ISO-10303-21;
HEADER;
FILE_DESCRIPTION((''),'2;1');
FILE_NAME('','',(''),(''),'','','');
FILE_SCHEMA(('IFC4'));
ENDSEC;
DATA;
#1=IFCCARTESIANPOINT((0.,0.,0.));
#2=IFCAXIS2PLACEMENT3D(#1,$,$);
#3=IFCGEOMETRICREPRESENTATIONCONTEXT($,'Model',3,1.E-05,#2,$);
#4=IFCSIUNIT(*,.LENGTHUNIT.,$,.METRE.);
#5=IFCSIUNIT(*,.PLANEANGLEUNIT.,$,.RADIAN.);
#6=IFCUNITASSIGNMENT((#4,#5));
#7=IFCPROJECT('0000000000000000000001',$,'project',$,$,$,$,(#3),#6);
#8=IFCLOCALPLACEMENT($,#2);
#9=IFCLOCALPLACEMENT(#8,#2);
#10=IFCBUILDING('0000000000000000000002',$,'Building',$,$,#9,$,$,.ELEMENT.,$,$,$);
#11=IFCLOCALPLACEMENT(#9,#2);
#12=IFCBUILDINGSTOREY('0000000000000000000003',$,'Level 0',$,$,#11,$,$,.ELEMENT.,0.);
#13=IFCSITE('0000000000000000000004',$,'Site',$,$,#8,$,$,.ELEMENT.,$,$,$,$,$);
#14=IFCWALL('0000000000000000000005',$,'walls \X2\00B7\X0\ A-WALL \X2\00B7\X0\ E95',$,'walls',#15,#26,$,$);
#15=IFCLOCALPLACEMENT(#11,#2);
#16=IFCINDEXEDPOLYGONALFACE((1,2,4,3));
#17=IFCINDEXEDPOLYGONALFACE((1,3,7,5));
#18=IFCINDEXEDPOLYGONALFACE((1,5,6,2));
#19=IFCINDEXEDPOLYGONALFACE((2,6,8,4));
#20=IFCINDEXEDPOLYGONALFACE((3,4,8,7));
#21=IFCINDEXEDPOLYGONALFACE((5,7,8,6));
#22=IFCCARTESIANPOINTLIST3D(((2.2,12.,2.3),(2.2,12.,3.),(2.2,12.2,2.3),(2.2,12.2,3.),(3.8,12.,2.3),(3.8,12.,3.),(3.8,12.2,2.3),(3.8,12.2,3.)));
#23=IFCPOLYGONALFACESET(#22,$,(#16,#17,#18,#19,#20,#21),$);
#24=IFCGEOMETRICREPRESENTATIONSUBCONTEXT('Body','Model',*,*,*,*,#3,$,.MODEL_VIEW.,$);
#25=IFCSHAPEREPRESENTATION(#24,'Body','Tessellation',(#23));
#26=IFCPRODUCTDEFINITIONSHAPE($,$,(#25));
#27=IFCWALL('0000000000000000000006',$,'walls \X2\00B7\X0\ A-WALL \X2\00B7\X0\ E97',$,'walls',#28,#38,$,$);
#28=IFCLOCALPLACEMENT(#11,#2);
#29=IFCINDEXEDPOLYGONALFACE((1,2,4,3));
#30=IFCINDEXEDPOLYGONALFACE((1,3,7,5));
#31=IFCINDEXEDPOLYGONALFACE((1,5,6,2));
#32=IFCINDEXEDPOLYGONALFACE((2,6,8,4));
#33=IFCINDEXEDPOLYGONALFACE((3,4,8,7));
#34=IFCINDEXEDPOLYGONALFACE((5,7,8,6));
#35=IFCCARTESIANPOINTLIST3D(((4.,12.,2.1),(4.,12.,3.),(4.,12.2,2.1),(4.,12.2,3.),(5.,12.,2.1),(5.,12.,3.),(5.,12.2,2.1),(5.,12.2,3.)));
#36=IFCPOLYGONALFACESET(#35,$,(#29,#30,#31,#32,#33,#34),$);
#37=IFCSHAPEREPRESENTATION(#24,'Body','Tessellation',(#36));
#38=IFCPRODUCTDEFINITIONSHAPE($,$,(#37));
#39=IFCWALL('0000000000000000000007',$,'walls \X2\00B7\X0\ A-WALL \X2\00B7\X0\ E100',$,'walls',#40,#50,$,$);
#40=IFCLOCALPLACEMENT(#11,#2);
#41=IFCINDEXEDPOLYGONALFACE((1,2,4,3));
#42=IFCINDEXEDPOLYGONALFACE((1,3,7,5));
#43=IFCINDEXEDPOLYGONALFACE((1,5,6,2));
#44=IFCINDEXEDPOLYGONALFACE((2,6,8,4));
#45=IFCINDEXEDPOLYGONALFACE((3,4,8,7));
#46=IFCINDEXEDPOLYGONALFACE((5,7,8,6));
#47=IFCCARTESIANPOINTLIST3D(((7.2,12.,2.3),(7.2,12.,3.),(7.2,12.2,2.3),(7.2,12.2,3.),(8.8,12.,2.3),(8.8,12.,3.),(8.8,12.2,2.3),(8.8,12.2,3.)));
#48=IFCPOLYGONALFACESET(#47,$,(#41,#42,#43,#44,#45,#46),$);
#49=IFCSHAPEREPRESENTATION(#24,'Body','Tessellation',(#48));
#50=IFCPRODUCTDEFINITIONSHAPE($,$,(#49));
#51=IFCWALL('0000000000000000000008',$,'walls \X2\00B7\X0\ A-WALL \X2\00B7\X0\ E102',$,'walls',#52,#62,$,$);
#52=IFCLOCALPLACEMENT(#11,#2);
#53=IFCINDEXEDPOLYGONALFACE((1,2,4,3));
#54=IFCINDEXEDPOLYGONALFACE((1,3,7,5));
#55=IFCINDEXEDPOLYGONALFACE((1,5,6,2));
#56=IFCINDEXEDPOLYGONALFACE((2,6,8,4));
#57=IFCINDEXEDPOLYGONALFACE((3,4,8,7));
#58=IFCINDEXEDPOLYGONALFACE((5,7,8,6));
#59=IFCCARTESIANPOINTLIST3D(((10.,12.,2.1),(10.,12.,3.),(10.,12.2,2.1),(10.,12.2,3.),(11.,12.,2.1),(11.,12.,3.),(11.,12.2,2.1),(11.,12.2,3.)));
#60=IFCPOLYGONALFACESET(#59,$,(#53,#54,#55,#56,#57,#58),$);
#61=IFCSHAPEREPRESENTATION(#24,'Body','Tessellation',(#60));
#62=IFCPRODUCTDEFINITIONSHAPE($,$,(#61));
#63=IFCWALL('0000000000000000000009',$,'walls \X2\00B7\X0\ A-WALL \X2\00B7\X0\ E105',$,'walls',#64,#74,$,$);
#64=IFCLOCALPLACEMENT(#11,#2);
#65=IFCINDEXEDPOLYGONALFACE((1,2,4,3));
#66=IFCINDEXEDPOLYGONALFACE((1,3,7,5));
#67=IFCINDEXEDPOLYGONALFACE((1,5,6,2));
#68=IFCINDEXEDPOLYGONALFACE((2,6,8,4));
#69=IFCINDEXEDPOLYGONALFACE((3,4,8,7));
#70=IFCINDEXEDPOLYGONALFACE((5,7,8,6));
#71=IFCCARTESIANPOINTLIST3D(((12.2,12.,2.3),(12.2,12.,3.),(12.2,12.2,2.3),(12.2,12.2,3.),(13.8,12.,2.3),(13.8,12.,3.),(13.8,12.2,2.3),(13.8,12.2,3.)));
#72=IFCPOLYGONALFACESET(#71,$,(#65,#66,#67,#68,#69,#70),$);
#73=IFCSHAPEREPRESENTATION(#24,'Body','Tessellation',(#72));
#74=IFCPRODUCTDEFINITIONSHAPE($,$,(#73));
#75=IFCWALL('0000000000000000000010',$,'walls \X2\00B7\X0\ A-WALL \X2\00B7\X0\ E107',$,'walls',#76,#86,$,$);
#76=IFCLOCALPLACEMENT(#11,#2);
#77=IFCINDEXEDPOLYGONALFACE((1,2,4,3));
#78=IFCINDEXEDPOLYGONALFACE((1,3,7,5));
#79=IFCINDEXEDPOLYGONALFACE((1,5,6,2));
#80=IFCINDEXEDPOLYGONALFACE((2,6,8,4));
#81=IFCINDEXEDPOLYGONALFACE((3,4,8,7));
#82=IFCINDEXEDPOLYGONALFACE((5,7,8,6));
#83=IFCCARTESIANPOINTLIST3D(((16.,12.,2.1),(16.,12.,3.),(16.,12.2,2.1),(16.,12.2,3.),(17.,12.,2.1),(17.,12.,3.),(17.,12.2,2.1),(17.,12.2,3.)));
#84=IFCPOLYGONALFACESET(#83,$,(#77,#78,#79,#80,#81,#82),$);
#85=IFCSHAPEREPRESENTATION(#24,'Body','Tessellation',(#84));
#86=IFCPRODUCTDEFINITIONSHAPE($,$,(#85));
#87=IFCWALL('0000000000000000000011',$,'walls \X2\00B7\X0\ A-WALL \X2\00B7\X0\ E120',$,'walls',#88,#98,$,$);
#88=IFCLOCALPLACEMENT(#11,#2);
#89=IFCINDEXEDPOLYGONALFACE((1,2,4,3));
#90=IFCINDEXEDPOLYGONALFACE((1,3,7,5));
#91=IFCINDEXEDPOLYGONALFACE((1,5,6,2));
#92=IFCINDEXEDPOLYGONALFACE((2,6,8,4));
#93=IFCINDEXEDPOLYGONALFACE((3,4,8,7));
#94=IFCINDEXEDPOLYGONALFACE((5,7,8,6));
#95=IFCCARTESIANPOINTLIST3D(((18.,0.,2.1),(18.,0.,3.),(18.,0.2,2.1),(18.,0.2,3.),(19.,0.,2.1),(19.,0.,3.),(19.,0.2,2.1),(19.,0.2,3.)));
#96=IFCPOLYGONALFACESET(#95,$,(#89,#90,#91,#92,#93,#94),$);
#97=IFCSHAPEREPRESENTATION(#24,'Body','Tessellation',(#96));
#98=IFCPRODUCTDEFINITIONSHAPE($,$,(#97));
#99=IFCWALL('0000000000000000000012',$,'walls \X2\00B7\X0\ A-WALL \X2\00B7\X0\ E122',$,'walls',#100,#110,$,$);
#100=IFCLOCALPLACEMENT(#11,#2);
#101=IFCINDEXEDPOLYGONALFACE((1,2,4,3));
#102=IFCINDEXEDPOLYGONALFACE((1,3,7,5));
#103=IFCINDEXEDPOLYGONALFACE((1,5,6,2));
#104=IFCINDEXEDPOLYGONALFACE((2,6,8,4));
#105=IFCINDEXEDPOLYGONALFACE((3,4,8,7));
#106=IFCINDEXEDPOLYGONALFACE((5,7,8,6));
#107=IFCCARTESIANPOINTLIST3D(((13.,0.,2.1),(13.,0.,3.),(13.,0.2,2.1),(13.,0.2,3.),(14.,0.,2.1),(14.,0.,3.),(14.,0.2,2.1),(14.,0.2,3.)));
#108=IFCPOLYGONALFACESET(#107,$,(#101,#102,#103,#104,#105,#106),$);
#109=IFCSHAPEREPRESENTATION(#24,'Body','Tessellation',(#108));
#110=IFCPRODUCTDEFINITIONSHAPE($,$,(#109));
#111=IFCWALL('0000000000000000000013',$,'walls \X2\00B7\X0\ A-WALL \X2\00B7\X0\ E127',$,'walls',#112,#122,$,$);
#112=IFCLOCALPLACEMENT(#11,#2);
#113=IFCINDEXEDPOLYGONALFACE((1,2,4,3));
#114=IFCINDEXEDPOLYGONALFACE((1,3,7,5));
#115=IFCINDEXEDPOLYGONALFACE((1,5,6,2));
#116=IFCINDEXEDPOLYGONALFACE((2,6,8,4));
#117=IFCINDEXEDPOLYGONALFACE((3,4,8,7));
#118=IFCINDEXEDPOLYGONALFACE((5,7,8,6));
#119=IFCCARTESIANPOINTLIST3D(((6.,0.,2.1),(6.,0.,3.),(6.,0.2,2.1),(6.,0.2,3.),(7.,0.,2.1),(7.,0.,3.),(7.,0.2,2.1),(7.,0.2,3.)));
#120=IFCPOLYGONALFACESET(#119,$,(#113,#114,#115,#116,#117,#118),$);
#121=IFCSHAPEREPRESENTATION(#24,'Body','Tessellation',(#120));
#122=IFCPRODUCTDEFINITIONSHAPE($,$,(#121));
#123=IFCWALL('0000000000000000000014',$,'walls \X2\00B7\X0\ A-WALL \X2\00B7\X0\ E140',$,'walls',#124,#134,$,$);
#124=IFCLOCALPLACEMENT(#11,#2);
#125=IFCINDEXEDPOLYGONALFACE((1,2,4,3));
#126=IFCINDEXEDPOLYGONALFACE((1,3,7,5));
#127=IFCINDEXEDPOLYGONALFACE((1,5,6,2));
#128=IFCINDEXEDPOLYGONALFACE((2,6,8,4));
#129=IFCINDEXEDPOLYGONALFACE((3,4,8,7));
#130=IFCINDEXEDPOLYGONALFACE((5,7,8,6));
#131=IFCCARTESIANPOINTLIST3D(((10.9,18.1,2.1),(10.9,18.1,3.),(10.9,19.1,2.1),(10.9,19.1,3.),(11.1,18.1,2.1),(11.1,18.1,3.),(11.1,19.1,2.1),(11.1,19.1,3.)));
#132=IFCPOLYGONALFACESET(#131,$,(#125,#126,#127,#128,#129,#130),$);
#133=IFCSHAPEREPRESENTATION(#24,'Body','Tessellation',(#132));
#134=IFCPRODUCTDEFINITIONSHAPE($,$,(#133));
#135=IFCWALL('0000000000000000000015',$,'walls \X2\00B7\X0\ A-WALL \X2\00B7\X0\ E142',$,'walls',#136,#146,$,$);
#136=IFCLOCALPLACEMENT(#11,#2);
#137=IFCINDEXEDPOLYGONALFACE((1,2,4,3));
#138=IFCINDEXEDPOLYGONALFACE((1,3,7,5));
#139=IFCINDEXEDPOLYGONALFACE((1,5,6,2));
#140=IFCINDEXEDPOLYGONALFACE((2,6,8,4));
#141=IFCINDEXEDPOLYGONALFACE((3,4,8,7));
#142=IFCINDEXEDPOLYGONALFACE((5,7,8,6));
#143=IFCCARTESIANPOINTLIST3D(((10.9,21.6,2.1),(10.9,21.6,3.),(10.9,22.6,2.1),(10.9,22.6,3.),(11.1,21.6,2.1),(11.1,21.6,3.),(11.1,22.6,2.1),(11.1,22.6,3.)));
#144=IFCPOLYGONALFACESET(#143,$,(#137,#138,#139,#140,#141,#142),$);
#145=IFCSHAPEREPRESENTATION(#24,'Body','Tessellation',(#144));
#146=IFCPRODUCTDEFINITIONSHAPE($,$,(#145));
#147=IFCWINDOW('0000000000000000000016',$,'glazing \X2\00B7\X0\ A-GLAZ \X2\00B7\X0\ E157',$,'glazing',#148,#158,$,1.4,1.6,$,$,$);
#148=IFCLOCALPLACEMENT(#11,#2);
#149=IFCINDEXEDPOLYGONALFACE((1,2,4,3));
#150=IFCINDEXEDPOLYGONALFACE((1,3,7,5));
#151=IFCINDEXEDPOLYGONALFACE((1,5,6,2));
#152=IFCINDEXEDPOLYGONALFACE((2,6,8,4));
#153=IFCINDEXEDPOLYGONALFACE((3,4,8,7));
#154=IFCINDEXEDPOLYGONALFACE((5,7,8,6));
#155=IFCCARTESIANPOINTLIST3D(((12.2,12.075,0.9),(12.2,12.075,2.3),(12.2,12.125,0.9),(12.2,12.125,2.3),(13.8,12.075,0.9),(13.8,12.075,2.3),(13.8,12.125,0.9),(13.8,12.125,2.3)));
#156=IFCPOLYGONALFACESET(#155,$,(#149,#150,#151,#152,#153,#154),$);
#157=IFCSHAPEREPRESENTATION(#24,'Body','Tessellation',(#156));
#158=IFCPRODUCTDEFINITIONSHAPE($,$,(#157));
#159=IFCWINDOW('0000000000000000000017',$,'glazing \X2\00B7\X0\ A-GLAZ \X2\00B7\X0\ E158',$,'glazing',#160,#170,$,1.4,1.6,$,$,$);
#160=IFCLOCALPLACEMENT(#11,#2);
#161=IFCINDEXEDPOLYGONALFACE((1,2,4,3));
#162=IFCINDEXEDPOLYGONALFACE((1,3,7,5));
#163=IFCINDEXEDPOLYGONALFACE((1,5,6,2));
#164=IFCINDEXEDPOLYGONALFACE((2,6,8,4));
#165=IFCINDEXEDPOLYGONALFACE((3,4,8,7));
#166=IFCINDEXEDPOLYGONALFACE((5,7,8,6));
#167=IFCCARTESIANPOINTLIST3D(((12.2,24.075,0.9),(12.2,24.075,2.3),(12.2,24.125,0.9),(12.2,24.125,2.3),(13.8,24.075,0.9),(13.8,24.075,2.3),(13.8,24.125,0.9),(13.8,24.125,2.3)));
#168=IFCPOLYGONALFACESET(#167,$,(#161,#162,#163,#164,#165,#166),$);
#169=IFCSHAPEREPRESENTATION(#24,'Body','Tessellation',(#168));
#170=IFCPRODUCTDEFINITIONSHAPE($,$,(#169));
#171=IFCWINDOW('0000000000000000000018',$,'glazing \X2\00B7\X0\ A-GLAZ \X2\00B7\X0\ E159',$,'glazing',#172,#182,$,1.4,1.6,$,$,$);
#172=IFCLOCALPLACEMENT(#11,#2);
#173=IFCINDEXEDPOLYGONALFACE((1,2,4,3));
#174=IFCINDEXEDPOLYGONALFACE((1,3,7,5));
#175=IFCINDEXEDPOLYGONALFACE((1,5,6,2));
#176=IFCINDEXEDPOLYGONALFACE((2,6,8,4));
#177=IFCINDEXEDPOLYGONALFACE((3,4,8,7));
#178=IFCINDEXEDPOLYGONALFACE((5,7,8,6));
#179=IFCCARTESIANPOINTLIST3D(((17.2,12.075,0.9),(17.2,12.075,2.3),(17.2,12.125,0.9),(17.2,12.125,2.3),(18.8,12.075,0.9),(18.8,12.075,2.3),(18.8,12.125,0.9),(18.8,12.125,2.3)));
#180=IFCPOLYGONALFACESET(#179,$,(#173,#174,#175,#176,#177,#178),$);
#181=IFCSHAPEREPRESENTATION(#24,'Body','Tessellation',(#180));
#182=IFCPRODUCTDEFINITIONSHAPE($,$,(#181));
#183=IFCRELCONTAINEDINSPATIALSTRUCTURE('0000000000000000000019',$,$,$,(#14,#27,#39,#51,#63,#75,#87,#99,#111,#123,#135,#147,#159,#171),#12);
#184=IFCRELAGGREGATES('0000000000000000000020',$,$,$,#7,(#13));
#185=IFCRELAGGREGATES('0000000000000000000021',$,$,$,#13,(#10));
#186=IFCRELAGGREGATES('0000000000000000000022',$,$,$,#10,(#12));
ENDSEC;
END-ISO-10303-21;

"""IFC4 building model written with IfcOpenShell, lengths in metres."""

from ifc_helpers import new_model, si_unit, frame, origin, place, context, subcontext, project, spatial, polyline, outline, extrude, element, save


model = new_model("IFC4")

# Units and contexts
model_context = context("Model", 3, precision=1e-05, world=origin())
body_context = subcontext(model_context, "Body", "Model", "MODEL_VIEW")
ifc_project = project(units=[si_unit("LENGTHUNIT", "METRE"), si_unit("PLANEANGLEUNIT", "RADIAN")], contexts=[model_context])

# Site, building, storey
site_placement = place(None, origin())
site = spatial("IfcSite", under=ifc_project, at=site_placement, Name="Site", CompositionType="ELEMENT")
building_placement = place(site_placement, origin())
building = spatial("IfcBuilding", under=site, at=building_placement, Name="Building", CompositionType="ELEMENT")
storey_placement = place(building_placement, origin())
storey = spatial("IfcBuildingStorey", under=building, at=storey_placement, Name="Level 0", CompositionType="ELEMENT", Elevation=0.0)

# Wall
wall_1_placement = place(storey_placement, frame((0.0, 0.0, 2.3)))
element("IfcWall", 1, at=wall_1_placement, inside=storey, Name="walls · A-WALL · E95", ObjectType="walls", context=body_context, shape_type="SweptSolid", body=[
    extrude(outline(polyline([(2.2, 12.0), (3.8, 12.0), (3.8, 12.2), (2.2, 12.2), (2.2, 12.0)])), origin(), (0.0, 0.0, 1.0), 0.7),
])

# Wall, opening
wall_2_placement = place(storey_placement, frame((0.0, 0.0, 2.1)))
wall_2 = element("IfcWall", 2, at=wall_2_placement, inside=storey, Name="walls · A-WALL · E97", ObjectType="walls", context=body_context, shape_type="SweptSolid", body=[
    extrude(outline(polyline([(4.0, 12.0), (5.0, 12.0), (5.0, 12.2), (4.0, 12.2), (4.0, 12.0)])), origin(), (0.0, 0.0, 1.0), 0.9),
])
opening_1_placement = place(storey_placement, origin())
element("IfcOpeningElement", 3, at=opening_1_placement, cuts=wall_2, ObjectType="Opening", context=body_context, shape_type="SweptSolid", body=[
    extrude(outline(polyline([(4.0, 12.0), (5.0, 12.0), (5.0, 12.2), (4.0, 12.2), (4.0, 12.0)])), origin(), (0.0, 0.0, 1.0), 2.1),
])

# Wall
wall_3_placement = place(storey_placement, frame((0.0, 0.0, 2.3)))
element("IfcWall", 4, at=wall_3_placement, inside=storey, Name="walls · A-WALL · E100", ObjectType="walls", context=body_context, shape_type="SweptSolid", body=[
    extrude(outline(polyline([(7.2, 12.0), (8.8, 12.0), (8.8, 12.2), (7.2, 12.2), (7.2, 12.0)])), origin(), (0.0, 0.0, 1.0), 0.7),
])

# Wall, opening
wall_4_placement = place(storey_placement, frame((0.0, 0.0, 2.1)))
wall_4 = element("IfcWall", 5, at=wall_4_placement, inside=storey, Name="walls · A-WALL · E102", ObjectType="walls", context=body_context, shape_type="SweptSolid", body=[
    extrude(outline(polyline([(10.0, 12.0), (11.0, 12.0), (11.0, 12.2), (10.0, 12.2), (10.0, 12.0)])), origin(), (0.0, 0.0, 1.0), 0.9),
])
opening_2_placement = place(storey_placement, origin())
element("IfcOpeningElement", 6, at=opening_2_placement, cuts=wall_4, ObjectType="Opening", context=body_context, shape_type="SweptSolid", body=[
    extrude(outline(polyline([(10.0, 12.0), (11.0, 12.0), (11.0, 12.2), (10.0, 12.2), (10.0, 12.0)])), origin(), (0.0, 0.0, 1.0), 2.1),
])

# Wall
wall_5_placement = place(storey_placement, frame((0.0, 0.0, 2.3)))
element("IfcWall", 7, at=wall_5_placement, inside=storey, Name="walls · A-WALL · E105", ObjectType="walls", context=body_context, shape_type="SweptSolid", body=[
    extrude(outline(polyline([(12.2, 12.0), (13.8, 12.0), (13.8, 12.2), (12.2, 12.2), (12.2, 12.0)])), origin(), (0.0, 0.0, 1.0), 0.7),
])

# Walls, openings
wall_6_placement = place(storey_placement, frame((0.0, 0.0, 2.1)))
wall_6 = element("IfcWall", 8, at=wall_6_placement, inside=storey, Name="walls · A-WALL · E107", ObjectType="walls", context=body_context, shape_type="SweptSolid", body=[
    extrude(outline(polyline([(16.0, 12.0), (17.0, 12.0), (17.0, 12.2), (16.0, 12.2), (16.0, 12.0)])), origin(), (0.0, 0.0, 1.0), 0.9),
])
opening_3_placement = place(storey_placement, origin())
element("IfcOpeningElement", 9, at=opening_3_placement, cuts=wall_6, ObjectType="Opening", context=body_context, shape_type="SweptSolid", body=[
    extrude(outline(polyline([(16.0, 12.0), (17.0, 12.0), (17.0, 12.2), (16.0, 12.2), (16.0, 12.0)])), origin(), (0.0, 0.0, 1.0), 2.1),
])
wall_7_placement = place(storey_placement, frame((0.0, 0.0, 2.1)))
wall_7 = element("IfcWall", 10, at=wall_7_placement, inside=storey, Name="walls · A-WALL · E120", ObjectType="walls", context=body_context, shape_type="SweptSolid", body=[
    extrude(outline(polyline([(19.0, 0.2), (18.0, 0.2), (18.0, 0.0), (19.0, 0.0), (19.0, 0.2)])), origin(), (0.0, 0.0, 1.0), 0.9),
])
opening_4_placement = place(storey_placement, origin())
element("IfcOpeningElement", 11, at=opening_4_placement, cuts=wall_7, ObjectType="Opening", context=body_context, shape_type="SweptSolid", body=[
    extrude(outline(polyline([(19.0, 0.2), (18.0, 0.2), (18.0, 0.0), (19.0, 0.0), (19.0, 0.2)])), origin(), (0.0, 0.0, 1.0), 2.1),
])
wall_8_placement = place(storey_placement, frame((0.0, 0.0, 2.1)))
wall_8 = element("IfcWall", 12, at=wall_8_placement, inside=storey, Name="walls · A-WALL · E122", ObjectType="walls", context=body_context, shape_type="SweptSolid", body=[
    extrude(outline(polyline([(14.0, 0.2), (13.0, 0.2), (13.0, 0.0), (14.0, 0.0), (14.0, 0.2)])), origin(), (0.0, 0.0, 1.0), 0.9),
])
opening_5_placement = place(storey_placement, origin())
element("IfcOpeningElement", 13, at=opening_5_placement, cuts=wall_8, ObjectType="Opening", context=body_context, shape_type="SweptSolid", body=[
    extrude(outline(polyline([(14.0, 0.2), (13.0, 0.2), (13.0, 0.0), (14.0, 0.0), (14.0, 0.2)])), origin(), (0.0, 0.0, 1.0), 2.1),
])
wall_9_placement = place(storey_placement, frame((0.0, 0.0, 2.1)))
wall_9 = element("IfcWall", 14, at=wall_9_placement, inside=storey, Name="walls · A-WALL · E127", ObjectType="walls", context=body_context, shape_type="SweptSolid", body=[
    extrude(outline(polyline([(7.0, 0.2), (6.0, 0.2), (6.0, 0.0), (7.0, 0.0), (7.0, 0.2)])), origin(), (0.0, 0.0, 1.0), 0.9),
])
opening_6_placement = place(storey_placement, origin())
element("IfcOpeningElement", 15, at=opening_6_placement, cuts=wall_9, ObjectType="Opening", context=body_context, shape_type="SweptSolid", body=[
    extrude(outline(polyline([(7.0, 0.2), (6.0, 0.2), (6.0, 0.0), (7.0, 0.0), (7.0, 0.2)])), origin(), (0.0, 0.0, 1.0), 2.1),
])
wall_10_placement = place(storey_placement, frame((0.0, 0.0, 2.1)))
wall_10 = element("IfcWall", 16, at=wall_10_placement, inside=storey, Name="walls · A-WALL · E140", ObjectType="walls", context=body_context, shape_type="SweptSolid", body=[
    extrude(outline(polyline([(11.1, 18.1), (11.1, 19.1), (10.9, 19.1), (10.9, 18.1), (11.1, 18.1)])), origin(), (0.0, 0.0, 1.0), 0.9),
])
opening_7_placement = place(storey_placement, origin())
element("IfcOpeningElement", 17, at=opening_7_placement, cuts=wall_10, ObjectType="Opening", context=body_context, shape_type="SweptSolid", body=[
    extrude(outline(polyline([(11.1, 18.1), (11.1, 19.1), (10.9, 19.1), (10.9, 18.1), (11.1, 18.1)])), origin(), (0.0, 0.0, 1.0), 2.1),
])
wall_11_placement = place(storey_placement, frame((0.0, 0.0, 2.1)))
wall_11 = element("IfcWall", 18, at=wall_11_placement, inside=storey, Name="walls · A-WALL · E142", ObjectType="walls", context=body_context, shape_type="SweptSolid", body=[
    extrude(outline(polyline([(11.1, 21.6), (11.1, 22.6), (10.9, 22.6), (10.9, 21.6), (11.1, 21.6)])), origin(), (0.0, 0.0, 1.0), 0.9),
])
opening_8_placement = place(storey_placement, origin())
element("IfcOpeningElement", 19, at=opening_8_placement, cuts=wall_11, ObjectType="Opening", context=body_context, shape_type="SweptSolid", body=[
    extrude(outline(polyline([(11.1, 21.6), (11.1, 22.6), (10.9, 22.6), (10.9, 21.6), (11.1, 21.6)])), origin(), (0.0, 0.0, 1.0), 2.1),
])

# Windows
window_1_placement = place(storey_placement, frame((0.0, 0.0, 0.9)))
element("IfcWindow", 20, at=window_1_placement, inside=storey, Name="glazing · A-GLAZ · E157", ObjectType="glazing", OverallHeight=1.4, OverallWidth=1.6, context=body_context, shape_type="SweptSolid", body=[
    extrude(outline(polyline([(12.2, 12.075), (13.8, 12.075), (13.8, 12.125), (12.2, 12.125), (12.2, 12.075)])), origin(), (0.0, 0.0, 1.0), 1.4),
])
window_2_placement = place(storey_placement, frame((0.0, 0.0, 0.9)))
element("IfcWindow", 21, at=window_2_placement, inside=storey, Name="glazing · A-GLAZ · E158", ObjectType="glazing", OverallHeight=1.4, OverallWidth=1.6, context=body_context, shape_type="SweptSolid", body=[
    extrude(outline(polyline([(13.8, 24.125), (12.2, 24.125), (12.2, 24.075), (13.8, 24.075), (13.8, 24.125)])), origin(), (0.0, 0.0, 1.0), 1.4),
])
window_3_placement = place(storey_placement, frame((0.0, 0.0, 0.9)))
element("IfcWindow", 22, at=window_3_placement, inside=storey, Name="glazing · A-GLAZ · E159", ObjectType="glazing", OverallHeight=1.4, OverallWidth=1.6, context=body_context, shape_type="SweptSolid", body=[
    extrude(outline(polyline([(17.2, 12.075), (18.8, 12.075), (18.8, 12.125), (17.2, 12.125), (17.2, 12.075)])), origin(), (0.0, 0.0, 1.0), 1.4),
])

save(model, "model.ifc")
